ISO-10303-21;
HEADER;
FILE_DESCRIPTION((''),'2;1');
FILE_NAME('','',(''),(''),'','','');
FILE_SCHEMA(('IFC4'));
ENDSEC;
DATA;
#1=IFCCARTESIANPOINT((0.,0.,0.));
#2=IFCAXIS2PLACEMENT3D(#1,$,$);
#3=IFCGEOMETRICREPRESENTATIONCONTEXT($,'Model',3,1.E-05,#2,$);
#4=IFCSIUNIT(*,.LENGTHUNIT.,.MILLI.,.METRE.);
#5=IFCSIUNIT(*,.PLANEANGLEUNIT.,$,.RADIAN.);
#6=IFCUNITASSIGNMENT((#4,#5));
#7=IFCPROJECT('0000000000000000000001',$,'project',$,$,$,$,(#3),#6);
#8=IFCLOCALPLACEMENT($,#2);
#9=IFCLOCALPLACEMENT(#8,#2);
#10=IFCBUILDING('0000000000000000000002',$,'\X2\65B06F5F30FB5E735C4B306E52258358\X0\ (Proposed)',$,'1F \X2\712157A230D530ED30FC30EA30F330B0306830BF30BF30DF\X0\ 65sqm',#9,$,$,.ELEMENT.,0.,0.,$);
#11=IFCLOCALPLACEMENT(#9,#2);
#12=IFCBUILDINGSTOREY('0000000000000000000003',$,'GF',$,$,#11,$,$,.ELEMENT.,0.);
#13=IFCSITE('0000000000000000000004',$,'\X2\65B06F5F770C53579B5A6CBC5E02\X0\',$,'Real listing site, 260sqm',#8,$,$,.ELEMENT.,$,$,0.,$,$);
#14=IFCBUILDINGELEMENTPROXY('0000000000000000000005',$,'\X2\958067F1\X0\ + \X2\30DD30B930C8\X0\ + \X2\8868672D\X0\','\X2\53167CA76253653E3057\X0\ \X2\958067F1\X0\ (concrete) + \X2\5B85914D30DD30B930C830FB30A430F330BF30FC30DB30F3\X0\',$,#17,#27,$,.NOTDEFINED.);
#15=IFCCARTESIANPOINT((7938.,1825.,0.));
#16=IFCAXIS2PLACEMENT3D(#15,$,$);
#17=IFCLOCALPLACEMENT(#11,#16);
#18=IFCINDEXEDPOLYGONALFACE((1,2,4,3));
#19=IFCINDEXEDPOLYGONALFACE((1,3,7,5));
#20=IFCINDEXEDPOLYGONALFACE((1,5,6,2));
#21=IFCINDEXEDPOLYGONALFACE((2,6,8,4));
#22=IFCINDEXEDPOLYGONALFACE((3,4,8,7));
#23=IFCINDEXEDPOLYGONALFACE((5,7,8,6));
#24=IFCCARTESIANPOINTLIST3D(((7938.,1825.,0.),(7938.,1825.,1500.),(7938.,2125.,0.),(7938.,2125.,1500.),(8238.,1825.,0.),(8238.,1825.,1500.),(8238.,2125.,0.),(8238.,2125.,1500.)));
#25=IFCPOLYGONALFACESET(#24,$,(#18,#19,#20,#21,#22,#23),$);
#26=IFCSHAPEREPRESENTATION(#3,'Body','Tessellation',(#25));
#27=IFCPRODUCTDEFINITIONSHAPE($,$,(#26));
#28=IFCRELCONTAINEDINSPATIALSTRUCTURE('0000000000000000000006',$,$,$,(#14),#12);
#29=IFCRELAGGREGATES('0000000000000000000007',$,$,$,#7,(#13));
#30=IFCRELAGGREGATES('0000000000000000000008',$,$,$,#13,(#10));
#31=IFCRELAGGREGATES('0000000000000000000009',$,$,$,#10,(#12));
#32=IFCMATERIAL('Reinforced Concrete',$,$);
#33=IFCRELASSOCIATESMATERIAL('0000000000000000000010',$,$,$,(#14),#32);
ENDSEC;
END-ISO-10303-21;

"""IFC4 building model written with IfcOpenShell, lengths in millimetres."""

from ifc_helpers import new_model, si_unit, frame, frame_2d, origin, place, context, project, spatial, rectangle, extrude, material, element, save


model = new_model("IFC4")

# Units and contexts
model_context = context("Model", 3, precision=1e-05, world=origin())
ifc_project = project(units=[si_unit("LENGTHUNIT", "METRE", prefix="MILLI"), si_unit("PLANEANGLEUNIT", "RADIAN")], contexts=[model_context])

# Site, building, storey
site_placement = place(None, origin())
site = spatial("IfcSite", under=ifc_project, at=site_placement, Name="新潟県南魚沼市", ObjectType="Real listing site, 260sqm", CompositionType="ELEMENT", RefElevation=0.0)
building_placement = place(site_placement, origin())
building = spatial("IfcBuilding", under=site, at=building_placement, Name="新潟・平屋の別荘 (Proposed)", ObjectType="1F 無垢フローリングとタタミ 65sqm", CompositionType="ELEMENT", ElevationOfRefHeight=0.0, ElevationOfTerrain=0.0)
storey_placement = place(building_placement, origin())
storey = spatial("IfcBuildingStorey", under=building, at=storey_placement, Name="GF", CompositionType="ELEMENT", Elevation=0.0)

# Shared definitions
ifc_material_1 = material(Name="Reinforced Concrete")

# Building element proxy
proxy_placement = place(storey_placement, frame((7938.0, 1825.0, 0.0)))
element("IfcBuildingElementProxy", 1, at=proxy_placement, inside=storey, material=ifc_material_1, Name="門柱 + ポスト + 表札", Description="化粧打放し 門柱 (concrete) + 宅配ポスト・インターホン", PredefinedType="NOTDEFINED", context=model_context, shape_type="SweptSolid", body=[
    extrude(rectangle(XDim=300.0, YDim=300.0, at=frame_2d((150.0, 150.0))), frame((7938.0, 1825.0, 0.0)), (0.0, 0.0, 1.0), 1500.0),
])

save(model, "model.ifc")
